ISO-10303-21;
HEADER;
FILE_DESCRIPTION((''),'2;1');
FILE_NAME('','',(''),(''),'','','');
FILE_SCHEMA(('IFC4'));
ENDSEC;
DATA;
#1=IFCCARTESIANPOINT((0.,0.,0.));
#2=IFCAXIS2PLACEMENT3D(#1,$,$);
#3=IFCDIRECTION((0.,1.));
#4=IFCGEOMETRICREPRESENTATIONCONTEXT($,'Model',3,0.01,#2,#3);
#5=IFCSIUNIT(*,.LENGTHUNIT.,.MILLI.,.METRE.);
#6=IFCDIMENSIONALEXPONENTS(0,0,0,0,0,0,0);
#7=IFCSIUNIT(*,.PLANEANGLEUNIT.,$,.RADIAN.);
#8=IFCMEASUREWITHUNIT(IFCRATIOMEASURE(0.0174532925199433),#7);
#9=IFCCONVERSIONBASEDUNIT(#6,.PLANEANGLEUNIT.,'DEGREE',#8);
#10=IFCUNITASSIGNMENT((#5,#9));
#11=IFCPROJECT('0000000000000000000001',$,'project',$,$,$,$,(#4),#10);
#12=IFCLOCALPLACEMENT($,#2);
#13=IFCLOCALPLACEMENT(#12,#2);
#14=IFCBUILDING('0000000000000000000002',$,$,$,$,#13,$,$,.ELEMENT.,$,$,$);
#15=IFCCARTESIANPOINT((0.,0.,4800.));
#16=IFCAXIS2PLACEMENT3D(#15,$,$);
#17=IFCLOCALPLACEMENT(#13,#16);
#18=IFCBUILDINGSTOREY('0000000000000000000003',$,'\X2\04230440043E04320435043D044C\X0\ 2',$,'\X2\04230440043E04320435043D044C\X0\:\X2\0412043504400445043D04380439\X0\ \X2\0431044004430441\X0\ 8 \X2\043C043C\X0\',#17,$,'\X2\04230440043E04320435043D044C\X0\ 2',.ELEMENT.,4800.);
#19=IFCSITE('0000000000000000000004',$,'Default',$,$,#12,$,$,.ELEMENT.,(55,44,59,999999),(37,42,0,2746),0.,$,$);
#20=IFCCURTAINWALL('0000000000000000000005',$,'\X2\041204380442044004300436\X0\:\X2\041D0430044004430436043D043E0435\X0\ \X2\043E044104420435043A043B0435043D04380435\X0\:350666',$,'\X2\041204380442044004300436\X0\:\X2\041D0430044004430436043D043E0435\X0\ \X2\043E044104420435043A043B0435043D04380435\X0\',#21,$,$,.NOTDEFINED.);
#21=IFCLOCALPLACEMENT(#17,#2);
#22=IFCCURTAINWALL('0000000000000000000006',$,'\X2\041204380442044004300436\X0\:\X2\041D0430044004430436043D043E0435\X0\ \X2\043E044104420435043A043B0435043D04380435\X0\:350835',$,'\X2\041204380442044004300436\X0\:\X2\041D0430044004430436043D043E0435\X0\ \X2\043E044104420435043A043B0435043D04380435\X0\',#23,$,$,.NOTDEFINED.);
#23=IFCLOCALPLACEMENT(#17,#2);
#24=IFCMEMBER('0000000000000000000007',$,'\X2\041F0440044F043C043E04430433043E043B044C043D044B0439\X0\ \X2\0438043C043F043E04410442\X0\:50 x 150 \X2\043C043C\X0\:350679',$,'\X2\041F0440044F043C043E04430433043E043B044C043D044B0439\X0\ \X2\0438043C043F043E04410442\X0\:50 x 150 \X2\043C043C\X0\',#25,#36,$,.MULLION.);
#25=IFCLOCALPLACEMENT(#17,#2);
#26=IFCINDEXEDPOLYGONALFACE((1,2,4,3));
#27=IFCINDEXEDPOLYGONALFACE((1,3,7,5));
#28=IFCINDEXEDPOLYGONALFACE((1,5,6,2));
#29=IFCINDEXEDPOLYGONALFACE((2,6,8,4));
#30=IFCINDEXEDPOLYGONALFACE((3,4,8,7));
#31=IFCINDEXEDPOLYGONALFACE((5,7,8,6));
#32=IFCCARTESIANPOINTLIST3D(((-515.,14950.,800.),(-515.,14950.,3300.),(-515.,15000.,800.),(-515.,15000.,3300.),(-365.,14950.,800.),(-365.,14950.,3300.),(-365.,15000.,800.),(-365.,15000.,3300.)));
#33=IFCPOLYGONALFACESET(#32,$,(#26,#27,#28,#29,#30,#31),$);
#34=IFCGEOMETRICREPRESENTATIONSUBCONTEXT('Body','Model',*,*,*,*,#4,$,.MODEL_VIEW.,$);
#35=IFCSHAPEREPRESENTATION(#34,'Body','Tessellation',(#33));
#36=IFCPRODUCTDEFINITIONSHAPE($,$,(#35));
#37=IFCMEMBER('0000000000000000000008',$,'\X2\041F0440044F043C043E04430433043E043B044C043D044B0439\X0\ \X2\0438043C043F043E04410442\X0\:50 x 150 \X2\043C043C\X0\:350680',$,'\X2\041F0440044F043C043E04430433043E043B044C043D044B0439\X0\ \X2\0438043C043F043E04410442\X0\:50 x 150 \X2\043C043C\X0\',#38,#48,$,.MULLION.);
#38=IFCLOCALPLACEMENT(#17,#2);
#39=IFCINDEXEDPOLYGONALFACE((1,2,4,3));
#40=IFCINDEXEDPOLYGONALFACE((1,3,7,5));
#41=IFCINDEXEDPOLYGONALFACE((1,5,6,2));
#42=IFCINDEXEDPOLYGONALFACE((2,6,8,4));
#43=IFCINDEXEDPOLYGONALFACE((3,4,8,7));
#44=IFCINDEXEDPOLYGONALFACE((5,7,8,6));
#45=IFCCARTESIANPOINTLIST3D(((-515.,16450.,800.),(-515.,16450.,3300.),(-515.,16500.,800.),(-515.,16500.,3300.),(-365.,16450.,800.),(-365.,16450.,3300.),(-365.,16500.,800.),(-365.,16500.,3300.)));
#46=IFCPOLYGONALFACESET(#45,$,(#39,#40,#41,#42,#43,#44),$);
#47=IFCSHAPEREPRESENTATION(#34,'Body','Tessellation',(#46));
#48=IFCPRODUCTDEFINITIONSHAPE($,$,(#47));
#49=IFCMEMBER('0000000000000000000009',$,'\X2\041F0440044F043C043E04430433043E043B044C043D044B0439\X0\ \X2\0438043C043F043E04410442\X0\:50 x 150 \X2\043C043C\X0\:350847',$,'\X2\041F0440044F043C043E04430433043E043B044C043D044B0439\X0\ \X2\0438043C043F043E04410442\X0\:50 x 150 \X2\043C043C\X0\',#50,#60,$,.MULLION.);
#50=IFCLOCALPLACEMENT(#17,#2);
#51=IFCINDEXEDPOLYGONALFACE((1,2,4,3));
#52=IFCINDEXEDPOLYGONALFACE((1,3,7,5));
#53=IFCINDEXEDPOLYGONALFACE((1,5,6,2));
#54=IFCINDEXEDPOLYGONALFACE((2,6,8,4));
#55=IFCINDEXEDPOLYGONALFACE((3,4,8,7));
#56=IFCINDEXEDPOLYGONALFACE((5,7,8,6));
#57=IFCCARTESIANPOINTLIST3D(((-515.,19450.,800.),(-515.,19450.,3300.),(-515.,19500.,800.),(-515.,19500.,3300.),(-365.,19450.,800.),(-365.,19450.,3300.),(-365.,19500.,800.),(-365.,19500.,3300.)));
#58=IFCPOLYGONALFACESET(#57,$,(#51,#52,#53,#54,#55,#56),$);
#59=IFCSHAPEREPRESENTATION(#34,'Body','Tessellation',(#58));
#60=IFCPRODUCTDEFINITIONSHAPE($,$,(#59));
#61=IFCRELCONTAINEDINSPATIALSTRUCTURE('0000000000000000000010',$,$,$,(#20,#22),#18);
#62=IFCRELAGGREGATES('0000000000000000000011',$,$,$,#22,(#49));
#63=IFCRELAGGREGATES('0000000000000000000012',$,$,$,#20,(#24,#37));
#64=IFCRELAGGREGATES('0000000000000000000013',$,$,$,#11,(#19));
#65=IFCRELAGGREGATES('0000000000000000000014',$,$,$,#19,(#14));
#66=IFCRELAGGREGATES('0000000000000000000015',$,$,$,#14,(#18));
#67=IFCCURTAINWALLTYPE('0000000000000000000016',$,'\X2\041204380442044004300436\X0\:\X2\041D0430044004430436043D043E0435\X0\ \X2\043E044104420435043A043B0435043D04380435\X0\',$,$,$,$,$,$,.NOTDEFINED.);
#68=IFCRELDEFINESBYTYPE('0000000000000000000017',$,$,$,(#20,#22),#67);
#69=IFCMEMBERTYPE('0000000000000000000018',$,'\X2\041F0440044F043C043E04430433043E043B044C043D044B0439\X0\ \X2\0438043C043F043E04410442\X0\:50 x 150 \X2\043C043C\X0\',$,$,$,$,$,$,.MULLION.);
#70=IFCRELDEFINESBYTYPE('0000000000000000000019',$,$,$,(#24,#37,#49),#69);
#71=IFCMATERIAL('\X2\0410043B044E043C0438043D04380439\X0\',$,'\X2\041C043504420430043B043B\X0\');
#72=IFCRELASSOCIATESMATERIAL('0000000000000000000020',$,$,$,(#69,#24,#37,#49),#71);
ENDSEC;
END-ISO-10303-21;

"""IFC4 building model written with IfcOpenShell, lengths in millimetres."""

from ifc_helpers import new_model, entity, si_unit, converted_unit, direction, frame, origin, origin_2d_with_axis, place, context, subcontext, project, spatial, rectangle, extrude, source, transform, mapped, material, material_profile, profile_set, profile_usage, type_object, type_shapes, element, aggregate, save


model = new_model("IFC4")

# Units and contexts
model_context = context("Model", 3, precision=0.01, world=origin(), true_north=direction((0.0, 1.0)))
body_context = subcontext(model_context, "Body", "Model", "MODEL_VIEW")
ifc_project = project(units=[si_unit("LENGTHUNIT", "METRE", prefix="MILLI"), converted_unit("PLANEANGLEUNIT", "DEGREE", entity("IfcRatioMeasure", 0.0174532925199433), si_unit("PLANEANGLEUNIT", "RADIAN"), dimensions=[0, 0, 0, 0, 0, 0, 0])], contexts=[model_context])

# Site, building, storey
site_placement = place(None, origin())
site = spatial("IfcSite", under=ifc_project, at=site_placement, Name="Default", CompositionType="ELEMENT", RefLatitude=(55, 44, 59, 999999), RefLongitude=(37, 42, 0, 2746), RefElevation=0.0)
building_placement = place(site_placement, origin())
building = spatial("IfcBuilding", under=site, at=building_placement, CompositionType="ELEMENT")
storey_placement = place(building_placement, frame((0.0, 0.0, 4800.0)))
storey = spatial("IfcBuildingStorey", under=building, at=storey_placement, Name="Уровень 2", ObjectType="Уровень:Верхний брус 8 мм", LongName="Уровень 2", CompositionType="ELEMENT", Elevation=4800.0)

# Curtain wall
curtain_wall_type = type_object("IfcCurtainWallType", Name="Витраж:Наружное остекление", PredefinedType="NOTDEFINED")
curtain_wall_1_placement = place(storey_placement, frame((0.0, 0.0, -4800.0)))
curtain_wall_1 = element("IfcCurtainWall", 1, at=curtain_wall_1_placement, inside=storey, type_object=curtain_wall_type, Name="Витраж:Наружное остекление:350666", ObjectType="Витраж:Наружное остекление", PredefinedType="NOTDEFINED")
ifc_material_1 = material(Name="Алюминий", Category="Металл")
ifc_material_profile = material_profile(ifc_material_1, rectangle(XDim=150.0, YDim=50.0, at=origin_2d_with_axis()), Name="50 x 150 мм")
ifc_profile_set = profile_set([ifc_material_profile], Name="50 x 150 мм")

# Curtain wall
curtain_wall_2_placement = place(storey_placement, frame((0.0, 0.0, -4800.0)))
curtain_wall_2 = element("IfcCurtainWall", 2, at=curtain_wall_2_placement, inside=storey, type_object=curtain_wall_type, Name="Витраж:Наружное остекление:350835", ObjectType="Витраж:Наружное остекление", PredefinedType="NOTDEFINED")

# Members
member_type_1 = type_object("IfcMemberType", Name="Прямоугольный импост:50 x 150 мм", PredefinedType="MULLION", material=ifc_profile_set)
shared_shape_1 = source(origin(), body_context, "Body", "SweptSolid", [
    extrude(rectangle(XDim=150.0, YDim=50.0, at=origin_2d_with_axis()), frame((0.0, 0.0, -2500.0), z_axis=(0.0, 0.0, 1.0), x_axis=(0.0, -1.0, 0.0)), (0.0, 0.0, 1.0), 2500.0),
])
type_shapes(member_type_1, [shared_shape_1])
ifc_profile_usage_1 = profile_usage(ifc_profile_set)
member_1_placement = place(storey_placement, frame((-440.0, 14975.0, 800.0), z_axis=(0.0, 0.0, -1.0), x_axis=(0.0, 1.0, 0.0)))
member_1 = element("IfcMember", 3, at=member_1_placement, type_object=member_type_1, material=ifc_profile_usage_1, Name="Прямоугольный импост:50 x 150 мм:350679", ObjectType="Прямоугольный импост:50 x 150 мм", PredefinedType="MULLION", context=body_context, shape_type="MappedRepresentation", body=[
    mapped(shared_shape_1, transform((0.0, 0.0, 0.0), scale=1.0)),
])
ifc_profile_usage_2 = profile_usage(ifc_profile_set)
member_2_placement = place(storey_placement, frame((-440.0, 16475.0, 800.0), z_axis=(0.0, 0.0, -1.0), x_axis=(0.0, 1.0, 0.0)))
member_2 = element("IfcMember", 4, at=member_2_placement, type_object=member_type_1, material=ifc_profile_usage_2, Name="Прямоугольный импост:50 x 150 мм:350680", ObjectType="Прямоугольный импост:50 x 150 мм", PredefinedType="MULLION", context=body_context, shape_type="MappedRepresentation", body=[
    mapped(shared_shape_1, transform((0.0, 0.0, 0.0), scale=1.0)),
])
ifc_profile_usage_3 = profile_usage(ifc_profile_set)
member_3_placement = place(storey_placement, frame((-440.0, 19475.0, 800.0), z_axis=(0.0, 0.0, -1.0), x_axis=(0.0, 1.0, 0.0)))
member_3 = element("IfcMember", 5, at=member_3_placement, type_object=member_type_1, material=ifc_profile_usage_3, Name="Прямоугольный импост:50 x 150 мм:350847", ObjectType="Прямоугольный импост:50 x 150 мм", PredefinedType="MULLION", context=body_context, shape_type="MappedRepresentation", body=[
    mapped(shared_shape_1, transform((0.0, 0.0, 0.0), scale=1.0)),
])

aggregate(curtain_wall_2, [member_3])
aggregate(curtain_wall_1, [member_1, member_2])

save(model, "model.ifc")
